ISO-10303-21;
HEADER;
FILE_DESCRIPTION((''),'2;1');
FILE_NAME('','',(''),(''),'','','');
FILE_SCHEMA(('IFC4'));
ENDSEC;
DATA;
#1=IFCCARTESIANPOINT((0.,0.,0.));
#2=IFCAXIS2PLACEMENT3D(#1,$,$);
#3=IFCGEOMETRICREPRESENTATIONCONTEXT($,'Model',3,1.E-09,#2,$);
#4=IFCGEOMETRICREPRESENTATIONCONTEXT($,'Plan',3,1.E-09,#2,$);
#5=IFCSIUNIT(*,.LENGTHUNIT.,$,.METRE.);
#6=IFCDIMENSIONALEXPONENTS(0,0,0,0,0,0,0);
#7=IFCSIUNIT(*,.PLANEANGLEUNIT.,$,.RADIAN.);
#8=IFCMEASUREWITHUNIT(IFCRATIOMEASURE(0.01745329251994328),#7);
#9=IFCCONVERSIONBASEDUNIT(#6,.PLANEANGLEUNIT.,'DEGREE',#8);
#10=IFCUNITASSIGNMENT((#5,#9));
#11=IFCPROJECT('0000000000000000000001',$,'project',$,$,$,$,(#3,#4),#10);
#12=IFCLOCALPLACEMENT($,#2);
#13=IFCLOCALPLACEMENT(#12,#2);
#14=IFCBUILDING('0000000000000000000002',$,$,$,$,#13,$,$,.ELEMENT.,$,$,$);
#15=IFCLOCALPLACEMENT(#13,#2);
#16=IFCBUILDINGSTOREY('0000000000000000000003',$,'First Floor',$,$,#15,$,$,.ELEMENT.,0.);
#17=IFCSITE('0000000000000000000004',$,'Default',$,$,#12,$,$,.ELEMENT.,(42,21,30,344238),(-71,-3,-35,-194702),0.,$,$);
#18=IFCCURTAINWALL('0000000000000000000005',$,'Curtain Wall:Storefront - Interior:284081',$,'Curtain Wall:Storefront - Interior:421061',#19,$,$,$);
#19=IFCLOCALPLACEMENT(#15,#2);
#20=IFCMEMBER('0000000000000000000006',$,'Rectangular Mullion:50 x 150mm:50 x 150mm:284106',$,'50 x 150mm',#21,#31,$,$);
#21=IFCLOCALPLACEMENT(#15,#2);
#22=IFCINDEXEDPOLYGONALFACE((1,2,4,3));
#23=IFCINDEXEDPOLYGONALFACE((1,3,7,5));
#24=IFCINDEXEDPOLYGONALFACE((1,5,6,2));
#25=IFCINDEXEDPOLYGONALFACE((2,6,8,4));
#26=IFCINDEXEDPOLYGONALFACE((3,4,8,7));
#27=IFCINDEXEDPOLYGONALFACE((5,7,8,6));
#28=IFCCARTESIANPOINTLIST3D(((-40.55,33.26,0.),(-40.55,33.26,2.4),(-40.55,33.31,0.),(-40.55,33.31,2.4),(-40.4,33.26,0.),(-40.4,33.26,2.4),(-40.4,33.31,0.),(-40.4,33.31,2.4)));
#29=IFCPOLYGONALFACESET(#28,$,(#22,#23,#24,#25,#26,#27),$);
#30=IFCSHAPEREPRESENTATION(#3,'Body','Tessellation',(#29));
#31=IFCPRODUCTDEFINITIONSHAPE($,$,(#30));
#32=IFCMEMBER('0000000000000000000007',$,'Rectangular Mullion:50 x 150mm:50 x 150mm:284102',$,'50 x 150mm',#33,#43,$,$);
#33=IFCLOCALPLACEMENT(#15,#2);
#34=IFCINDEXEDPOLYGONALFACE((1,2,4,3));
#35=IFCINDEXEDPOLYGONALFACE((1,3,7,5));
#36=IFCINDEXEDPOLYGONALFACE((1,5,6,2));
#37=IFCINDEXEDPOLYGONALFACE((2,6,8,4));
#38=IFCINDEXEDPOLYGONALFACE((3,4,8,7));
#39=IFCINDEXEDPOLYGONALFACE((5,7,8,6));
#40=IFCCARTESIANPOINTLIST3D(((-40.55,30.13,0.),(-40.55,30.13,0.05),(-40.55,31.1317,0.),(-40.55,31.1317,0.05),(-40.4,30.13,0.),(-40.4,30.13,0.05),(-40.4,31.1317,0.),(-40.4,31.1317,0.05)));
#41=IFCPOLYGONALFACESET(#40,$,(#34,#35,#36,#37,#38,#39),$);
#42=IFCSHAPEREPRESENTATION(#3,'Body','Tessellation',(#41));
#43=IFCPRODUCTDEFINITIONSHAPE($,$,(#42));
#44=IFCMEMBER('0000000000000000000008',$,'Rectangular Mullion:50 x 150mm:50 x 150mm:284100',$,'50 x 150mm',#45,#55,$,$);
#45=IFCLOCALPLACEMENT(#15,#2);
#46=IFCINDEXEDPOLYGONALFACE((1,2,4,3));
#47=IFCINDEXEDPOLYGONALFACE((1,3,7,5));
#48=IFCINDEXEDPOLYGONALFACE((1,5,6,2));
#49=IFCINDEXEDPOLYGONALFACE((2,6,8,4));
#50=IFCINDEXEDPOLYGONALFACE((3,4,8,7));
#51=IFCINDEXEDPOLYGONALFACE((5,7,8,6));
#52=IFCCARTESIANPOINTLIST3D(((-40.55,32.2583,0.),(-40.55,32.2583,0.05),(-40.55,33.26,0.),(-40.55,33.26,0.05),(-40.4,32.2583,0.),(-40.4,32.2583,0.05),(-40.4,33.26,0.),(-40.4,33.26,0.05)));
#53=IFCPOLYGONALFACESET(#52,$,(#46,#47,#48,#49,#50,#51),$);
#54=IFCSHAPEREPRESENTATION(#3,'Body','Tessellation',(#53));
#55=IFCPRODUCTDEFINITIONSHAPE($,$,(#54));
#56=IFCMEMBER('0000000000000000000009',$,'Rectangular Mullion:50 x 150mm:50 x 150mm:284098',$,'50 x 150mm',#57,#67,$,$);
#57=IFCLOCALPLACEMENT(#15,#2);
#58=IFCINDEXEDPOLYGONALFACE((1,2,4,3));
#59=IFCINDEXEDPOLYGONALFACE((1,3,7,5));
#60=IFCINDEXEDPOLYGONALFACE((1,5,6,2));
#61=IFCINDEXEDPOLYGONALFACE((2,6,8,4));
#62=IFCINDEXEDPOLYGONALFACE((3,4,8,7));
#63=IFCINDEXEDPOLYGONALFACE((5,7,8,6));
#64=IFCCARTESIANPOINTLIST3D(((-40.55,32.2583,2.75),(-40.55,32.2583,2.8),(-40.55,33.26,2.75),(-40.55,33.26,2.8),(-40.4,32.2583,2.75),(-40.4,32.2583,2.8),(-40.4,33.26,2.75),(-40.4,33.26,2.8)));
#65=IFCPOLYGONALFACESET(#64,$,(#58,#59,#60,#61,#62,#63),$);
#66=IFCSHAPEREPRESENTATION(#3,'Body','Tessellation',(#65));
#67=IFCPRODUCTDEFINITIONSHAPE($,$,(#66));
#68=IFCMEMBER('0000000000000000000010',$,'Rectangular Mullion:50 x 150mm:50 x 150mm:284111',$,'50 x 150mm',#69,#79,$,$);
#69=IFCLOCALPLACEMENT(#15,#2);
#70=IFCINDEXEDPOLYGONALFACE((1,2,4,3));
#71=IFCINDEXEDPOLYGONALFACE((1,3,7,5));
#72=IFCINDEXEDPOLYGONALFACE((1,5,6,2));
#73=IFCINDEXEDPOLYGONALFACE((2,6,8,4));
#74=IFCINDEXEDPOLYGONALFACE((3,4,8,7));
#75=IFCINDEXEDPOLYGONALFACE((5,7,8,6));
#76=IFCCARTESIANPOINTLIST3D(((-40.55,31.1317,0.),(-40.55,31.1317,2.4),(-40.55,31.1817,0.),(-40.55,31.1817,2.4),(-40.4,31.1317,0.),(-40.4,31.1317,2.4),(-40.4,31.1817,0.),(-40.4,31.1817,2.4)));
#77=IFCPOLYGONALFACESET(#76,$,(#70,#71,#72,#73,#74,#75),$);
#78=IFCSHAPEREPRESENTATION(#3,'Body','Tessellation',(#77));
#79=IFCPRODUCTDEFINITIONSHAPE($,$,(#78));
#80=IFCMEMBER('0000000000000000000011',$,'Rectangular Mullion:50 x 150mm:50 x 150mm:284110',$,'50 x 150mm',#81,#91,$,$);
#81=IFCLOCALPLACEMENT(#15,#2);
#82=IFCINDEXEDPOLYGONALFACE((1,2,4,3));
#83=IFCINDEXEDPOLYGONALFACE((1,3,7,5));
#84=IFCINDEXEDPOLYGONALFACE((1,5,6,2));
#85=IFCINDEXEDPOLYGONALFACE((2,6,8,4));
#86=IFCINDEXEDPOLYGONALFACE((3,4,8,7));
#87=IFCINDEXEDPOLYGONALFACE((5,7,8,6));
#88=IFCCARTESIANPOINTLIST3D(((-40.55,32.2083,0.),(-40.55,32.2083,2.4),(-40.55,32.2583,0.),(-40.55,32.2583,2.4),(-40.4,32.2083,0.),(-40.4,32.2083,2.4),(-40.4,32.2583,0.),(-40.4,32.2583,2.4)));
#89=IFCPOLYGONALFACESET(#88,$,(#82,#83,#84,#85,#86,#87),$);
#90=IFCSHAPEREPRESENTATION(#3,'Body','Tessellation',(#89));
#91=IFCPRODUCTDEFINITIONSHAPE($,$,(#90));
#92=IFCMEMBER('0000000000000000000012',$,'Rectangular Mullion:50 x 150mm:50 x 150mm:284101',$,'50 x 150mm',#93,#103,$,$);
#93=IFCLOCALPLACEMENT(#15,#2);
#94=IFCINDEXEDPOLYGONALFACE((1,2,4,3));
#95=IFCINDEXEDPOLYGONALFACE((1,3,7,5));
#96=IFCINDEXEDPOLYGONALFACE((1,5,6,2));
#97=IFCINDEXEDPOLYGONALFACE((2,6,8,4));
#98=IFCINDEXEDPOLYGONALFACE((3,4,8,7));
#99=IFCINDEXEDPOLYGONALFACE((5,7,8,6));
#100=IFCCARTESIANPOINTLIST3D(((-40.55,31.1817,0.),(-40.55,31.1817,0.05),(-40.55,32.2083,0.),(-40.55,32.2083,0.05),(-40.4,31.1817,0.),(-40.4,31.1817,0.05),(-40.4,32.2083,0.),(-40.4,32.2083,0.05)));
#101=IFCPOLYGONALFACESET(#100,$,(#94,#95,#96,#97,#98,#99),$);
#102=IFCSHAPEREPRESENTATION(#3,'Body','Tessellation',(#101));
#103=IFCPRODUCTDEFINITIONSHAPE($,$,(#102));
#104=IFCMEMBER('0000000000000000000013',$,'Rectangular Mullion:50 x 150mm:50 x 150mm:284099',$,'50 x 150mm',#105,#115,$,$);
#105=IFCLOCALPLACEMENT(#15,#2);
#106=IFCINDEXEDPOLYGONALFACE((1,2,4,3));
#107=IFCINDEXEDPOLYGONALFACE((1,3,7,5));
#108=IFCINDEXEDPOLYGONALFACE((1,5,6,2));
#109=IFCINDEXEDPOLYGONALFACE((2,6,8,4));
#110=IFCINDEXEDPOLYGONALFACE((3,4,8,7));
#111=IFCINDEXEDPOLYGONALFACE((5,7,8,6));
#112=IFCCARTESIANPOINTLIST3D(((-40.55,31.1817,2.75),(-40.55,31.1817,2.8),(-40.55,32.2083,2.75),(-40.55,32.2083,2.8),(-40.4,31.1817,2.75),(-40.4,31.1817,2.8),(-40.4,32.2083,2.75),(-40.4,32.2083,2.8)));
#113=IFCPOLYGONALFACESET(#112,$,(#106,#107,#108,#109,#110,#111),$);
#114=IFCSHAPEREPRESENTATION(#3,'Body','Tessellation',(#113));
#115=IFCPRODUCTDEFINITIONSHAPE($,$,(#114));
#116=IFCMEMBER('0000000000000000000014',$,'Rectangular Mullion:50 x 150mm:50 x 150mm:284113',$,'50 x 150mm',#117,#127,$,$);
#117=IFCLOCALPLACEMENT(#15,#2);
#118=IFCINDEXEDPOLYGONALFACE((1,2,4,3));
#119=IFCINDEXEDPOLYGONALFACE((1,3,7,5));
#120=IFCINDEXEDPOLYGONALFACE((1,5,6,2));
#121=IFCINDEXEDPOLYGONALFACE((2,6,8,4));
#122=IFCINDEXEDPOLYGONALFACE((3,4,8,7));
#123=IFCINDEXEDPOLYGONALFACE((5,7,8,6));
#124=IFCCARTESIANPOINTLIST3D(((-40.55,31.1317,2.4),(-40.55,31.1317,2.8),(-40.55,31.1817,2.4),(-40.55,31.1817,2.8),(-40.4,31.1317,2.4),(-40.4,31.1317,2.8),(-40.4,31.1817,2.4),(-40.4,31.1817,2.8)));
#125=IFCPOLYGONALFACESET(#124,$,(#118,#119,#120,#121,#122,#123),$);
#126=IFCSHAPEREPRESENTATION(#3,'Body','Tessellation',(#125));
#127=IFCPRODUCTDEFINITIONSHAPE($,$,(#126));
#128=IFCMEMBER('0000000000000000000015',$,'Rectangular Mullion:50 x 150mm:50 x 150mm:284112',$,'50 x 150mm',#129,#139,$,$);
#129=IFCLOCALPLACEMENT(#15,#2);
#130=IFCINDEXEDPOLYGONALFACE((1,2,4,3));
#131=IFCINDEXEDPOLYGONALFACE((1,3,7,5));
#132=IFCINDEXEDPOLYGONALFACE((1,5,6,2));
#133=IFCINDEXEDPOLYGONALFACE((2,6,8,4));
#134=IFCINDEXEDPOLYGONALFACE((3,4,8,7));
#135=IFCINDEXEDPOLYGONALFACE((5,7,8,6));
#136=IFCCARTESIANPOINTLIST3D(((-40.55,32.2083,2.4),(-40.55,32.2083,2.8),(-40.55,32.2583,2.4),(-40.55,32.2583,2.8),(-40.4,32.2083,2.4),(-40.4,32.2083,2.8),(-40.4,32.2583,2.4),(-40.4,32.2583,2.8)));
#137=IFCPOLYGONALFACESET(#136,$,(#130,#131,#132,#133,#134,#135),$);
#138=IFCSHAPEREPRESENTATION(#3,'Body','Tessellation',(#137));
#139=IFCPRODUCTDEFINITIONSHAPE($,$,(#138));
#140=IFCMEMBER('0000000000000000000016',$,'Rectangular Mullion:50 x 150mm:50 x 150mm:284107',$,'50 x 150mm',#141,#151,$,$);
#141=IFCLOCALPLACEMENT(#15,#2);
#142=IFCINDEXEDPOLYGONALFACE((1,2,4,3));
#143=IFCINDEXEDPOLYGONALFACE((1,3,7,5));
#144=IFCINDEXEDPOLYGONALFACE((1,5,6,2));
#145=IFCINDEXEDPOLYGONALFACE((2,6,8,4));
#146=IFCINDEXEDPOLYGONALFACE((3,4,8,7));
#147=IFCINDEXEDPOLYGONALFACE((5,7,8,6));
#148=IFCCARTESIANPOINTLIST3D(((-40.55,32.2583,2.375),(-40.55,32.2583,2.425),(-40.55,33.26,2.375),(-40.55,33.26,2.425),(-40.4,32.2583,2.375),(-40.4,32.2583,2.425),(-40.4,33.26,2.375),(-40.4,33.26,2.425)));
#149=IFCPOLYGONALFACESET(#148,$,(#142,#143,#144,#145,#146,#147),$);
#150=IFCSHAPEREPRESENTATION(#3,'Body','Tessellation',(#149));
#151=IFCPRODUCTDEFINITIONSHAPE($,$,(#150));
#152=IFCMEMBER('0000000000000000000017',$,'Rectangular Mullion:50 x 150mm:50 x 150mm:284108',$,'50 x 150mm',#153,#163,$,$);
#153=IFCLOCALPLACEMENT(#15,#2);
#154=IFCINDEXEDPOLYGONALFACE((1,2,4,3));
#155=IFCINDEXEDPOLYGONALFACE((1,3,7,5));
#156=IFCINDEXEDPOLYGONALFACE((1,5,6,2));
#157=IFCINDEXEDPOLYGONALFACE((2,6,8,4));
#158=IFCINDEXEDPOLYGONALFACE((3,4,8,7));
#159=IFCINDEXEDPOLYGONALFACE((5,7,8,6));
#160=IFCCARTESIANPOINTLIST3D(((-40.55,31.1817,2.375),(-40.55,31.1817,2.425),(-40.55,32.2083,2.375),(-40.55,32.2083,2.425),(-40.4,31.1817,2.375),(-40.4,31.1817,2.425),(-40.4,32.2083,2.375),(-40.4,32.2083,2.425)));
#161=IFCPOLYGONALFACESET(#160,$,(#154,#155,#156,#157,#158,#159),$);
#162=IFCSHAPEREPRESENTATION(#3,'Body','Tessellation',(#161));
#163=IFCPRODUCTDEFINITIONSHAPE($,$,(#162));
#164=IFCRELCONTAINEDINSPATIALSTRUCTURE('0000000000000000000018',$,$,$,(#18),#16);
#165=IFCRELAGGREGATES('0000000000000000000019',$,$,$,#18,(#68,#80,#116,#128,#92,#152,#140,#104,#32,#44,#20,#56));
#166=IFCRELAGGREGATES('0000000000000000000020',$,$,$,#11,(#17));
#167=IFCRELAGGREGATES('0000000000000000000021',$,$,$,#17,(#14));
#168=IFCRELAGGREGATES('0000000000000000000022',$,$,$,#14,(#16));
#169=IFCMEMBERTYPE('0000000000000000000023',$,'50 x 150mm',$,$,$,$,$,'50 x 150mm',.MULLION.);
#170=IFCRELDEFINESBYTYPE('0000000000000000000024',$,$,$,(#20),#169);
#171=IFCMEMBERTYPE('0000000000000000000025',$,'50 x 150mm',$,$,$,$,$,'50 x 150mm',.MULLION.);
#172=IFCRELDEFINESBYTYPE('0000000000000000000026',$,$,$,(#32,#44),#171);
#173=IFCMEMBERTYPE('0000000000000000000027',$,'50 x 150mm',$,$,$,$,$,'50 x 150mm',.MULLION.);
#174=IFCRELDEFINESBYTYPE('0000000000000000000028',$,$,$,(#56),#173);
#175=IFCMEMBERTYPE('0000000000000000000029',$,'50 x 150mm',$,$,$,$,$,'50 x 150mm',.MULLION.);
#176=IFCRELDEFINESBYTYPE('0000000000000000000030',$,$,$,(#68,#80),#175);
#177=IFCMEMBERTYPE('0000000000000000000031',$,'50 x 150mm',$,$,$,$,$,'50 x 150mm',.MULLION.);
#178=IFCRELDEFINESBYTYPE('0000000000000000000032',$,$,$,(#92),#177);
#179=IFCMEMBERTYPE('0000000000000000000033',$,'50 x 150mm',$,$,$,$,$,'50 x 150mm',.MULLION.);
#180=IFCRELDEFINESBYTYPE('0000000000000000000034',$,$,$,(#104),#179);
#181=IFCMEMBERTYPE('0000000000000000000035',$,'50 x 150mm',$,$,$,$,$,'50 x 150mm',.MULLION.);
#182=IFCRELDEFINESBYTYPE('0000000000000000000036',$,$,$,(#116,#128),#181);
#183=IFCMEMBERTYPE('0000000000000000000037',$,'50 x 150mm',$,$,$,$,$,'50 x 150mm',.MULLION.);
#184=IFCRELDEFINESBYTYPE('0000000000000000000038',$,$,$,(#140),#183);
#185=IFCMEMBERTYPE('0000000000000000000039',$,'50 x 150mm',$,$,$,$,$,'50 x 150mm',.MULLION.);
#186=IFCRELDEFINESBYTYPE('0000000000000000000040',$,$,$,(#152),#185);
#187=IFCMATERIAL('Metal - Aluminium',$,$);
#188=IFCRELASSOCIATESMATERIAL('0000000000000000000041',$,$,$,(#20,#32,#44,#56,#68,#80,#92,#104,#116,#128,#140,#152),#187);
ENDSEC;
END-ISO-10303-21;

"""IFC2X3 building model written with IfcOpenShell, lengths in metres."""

from ifc_helpers import new_model, entity, si_unit, converted_unit, frame, origin, origin_2d_with_axis, place, context, project, spatial, rectangle, extrude, source, transform, mapped, material, type_object, type_shapes, element, aggregate, save


model = new_model("IFC2X3")

# Units and contexts
model_context = context("Model", 3, precision=1e-09, world=origin())
plan_context = context("Plan", 3, precision=1e-09, world=origin())
ifc_project = project(units=[si_unit("LENGTHUNIT", "METRE"), converted_unit("PLANEANGLEUNIT", "DEGREE", entity("IfcRatioMeasure", 0.01745329251994328), si_unit("PLANEANGLEUNIT", "RADIAN"), dimensions=[0, 0, 0, 0, 0, 0, 0])], contexts=[model_context, plan_context])

# Site, building, storey
site_placement = place(None, origin())
site = spatial("IfcSite", under=ifc_project, at=site_placement, Name="Default", CompositionType="ELEMENT", RefLatitude=(42, 21, 30, 344238), RefLongitude=(-71, -3, -35, -194702), RefElevation=0.0)
building_placement = place(site_placement, origin())
building = spatial("IfcBuilding", under=site, at=building_placement, CompositionType="ELEMENT")
storey_placement = place(building_placement, origin())
storey = spatial("IfcBuildingStorey", under=building, at=storey_placement, Name="First Floor", CompositionType="ELEMENT", Elevation=0.0)

# Curtain wall, members
curtain_wall_placement = place(storey_placement, origin())
curtain_wall = element("IfcCurtainWall", 1, at=curtain_wall_placement, inside=storey, Name="Curtain Wall:Storefront - Interior:284081", ObjectType="Curtain Wall:Storefront - Interior:421061")
ifc_material_1 = material(Name="Metal - Aluminium")
member_type_1 = type_object("IfcMemberType", Name="50 x 150mm", ElementType="50 x 150mm", PredefinedType="MULLION")
shared_shape_1 = source(origin(), model_context, "Body", "SweptSolid", [
    extrude(rectangle(XDim=0.05, YDim=0.15, at=origin_2d_with_axis()), frame((-0.025, 0.0, -2.4), z_axis=(0.0, 0.0, 1.0), x_axis=(-1.0, 0.0, 0.0)), (0.0, 0.0, 1.0), 2.4),
])
type_shapes(member_type_1, [shared_shape_1])
member_1_placement = place(storey_placement, frame((-40.475, 33.31, 2.4), z_axis=(0.0, 0.0, 1.0), x_axis=(0.0, 1.0, 0.0)))
member_1 = element("IfcMember", 2, at=member_1_placement, type_object=member_type_1, material=ifc_material_1, Name="Rectangular Mullion:50 x 150mm:50 x 150mm:284106", ObjectType="50 x 150mm", context=model_context, shape_type="MappedRepresentation", body=[
    mapped(shared_shape_1, transform((0.0, 0.0, 0.0), scale=1.0)),
])
member_type_2 = type_object("IfcMemberType", Name="50 x 150mm", ElementType="50 x 150mm", PredefinedType="MULLION")
shared_shape_2 = source(origin(), model_context, "Body", "SweptSolid", [
    extrude(rectangle(XDim=0.05, YDim=0.15, at=origin_2d_with_axis()), frame((-0.025, 0.0, -1.0017), z_axis=(0.0, 0.0, 1.0), x_axis=(-1.0, 0.0, 0.0)), (0.0, 0.0, 1.0), 1.0017),
])
type_shapes(member_type_2, [shared_shape_2])
member_2_placement = place(storey_placement, frame((-40.475, 31.1317, 0.0), z_axis=(0.0, 1.0, 0.0), x_axis=(0.0, 0.0, -1.0)))
member_2 = element("IfcMember", 3, at=member_2_placement, type_object=member_type_2, material=ifc_material_1, Name="Rectangular Mullion:50 x 150mm:50 x 150mm:284102", ObjectType="50 x 150mm", context=model_context, shape_type="MappedRepresentation", body=[
    mapped(shared_shape_2, transform((0.0, 0.0, 0.0), scale=1.0)),
])
member_3_placement = place(storey_placement, frame((-40.475, 33.26, 0.0), z_axis=(0.0, 1.0, 0.0), x_axis=(0.0, 0.0, -1.0)))
member_3 = element("IfcMember", 4, at=member_3_placement, type_object=member_type_2, material=ifc_material_1, Name="Rectangular Mullion:50 x 150mm:50 x 150mm:284100", ObjectType="50 x 150mm", context=model_context, shape_type="MappedRepresentation", body=[
    mapped(shared_shape_2, transform((0.0, 0.0, 0.0), scale=1.0)),
])
member_type_3 = type_object("IfcMemberType", Name="50 x 150mm", ElementType="50 x 150mm", PredefinedType="MULLION")
type_shapes(member_type_3, [shared_shape_2])
member_4_placement = place(storey_placement, frame((-40.475, 32.2583, 2.8), z_axis=(0.0, -1.0, 0.0), x_axis=(0.0, 0.0, 1.0)))
member_4 = element("IfcMember", 5, at=member_4_placement, type_object=member_type_3, material=ifc_material_1, Name="Rectangular Mullion:50 x 150mm:50 x 150mm:284098", ObjectType="50 x 150mm", context=model_context, shape_type="MappedRepresentation", body=[
    mapped(shared_shape_2, transform((0.0, 0.0, 0.0), scale=1.0)),
])
member_type_4 = type_object("IfcMemberType", Name="50 x 150mm", ElementType="50 x 150mm", PredefinedType="MULLION")
shared_shape_3 = source(origin(), model_context, "Body", "SweptSolid", [
    extrude(rectangle(XDim=0.05, YDim=0.15, at=origin_2d_with_axis()), frame((0.0, 0.0, -2.4), z_axis=(0.0, 0.0, 1.0), x_axis=(-1.0, 0.0, 0.0)), (0.0, 0.0, 1.0), 2.4),
])
type_shapes(member_type_4, [shared_shape_3])
member_5_placement = place(storey_placement, frame((-40.475, 31.1567, 0.0), z_axis=(0.0, 0.0, -1.0), x_axis=(0.0, -1.0, 0.0)))
member_5 = element("IfcMember", 6, at=member_5_placement, type_object=member_type_4, material=ifc_material_1, Name="Rectangular Mullion:50 x 150mm:50 x 150mm:284111", ObjectType="50 x 150mm", context=model_context, shape_type="MappedRepresentation", body=[
    mapped(shared_shape_3, transform((0.0, 0.0, 0.0), scale=1.0)),
])
member_6_placement = place(storey_placement, frame((-40.475, 32.2333, 0.0), z_axis=(0.0, 0.0, -1.0), x_axis=(0.0, -1.0, 0.0)))
member_6 = element("IfcMember", 7, at=member_6_placement, type_object=member_type_4, material=ifc_material_1, Name="Rectangular Mullion:50 x 150mm:50 x 150mm:284110", ObjectType="50 x 150mm", context=model_context, shape_type="MappedRepresentation", body=[
    mapped(shared_shape_3, transform((0.0, 0.0, 0.0), scale=1.0)),
])
member_type_5 = type_object("IfcMemberType", Name="50 x 150mm", ElementType="50 x 150mm", PredefinedType="MULLION")
shared_shape_4 = source(origin(), model_context, "Body", "SweptSolid", [
    extrude(rectangle(XDim=0.05, YDim=0.15, at=origin_2d_with_axis()), frame((-0.025, 0.0, -1.0267), z_axis=(0.0, 0.0, 1.0), x_axis=(-1.0, 0.0, 0.0)), (0.0, 0.0, 1.0), 1.0267),
])
type_shapes(member_type_5, [shared_shape_4])
member_7_placement = place(storey_placement, frame((-40.475, 32.2083, 0.0), z_axis=(0.0, 1.0, 0.0), x_axis=(0.0, 0.0, -1.0)))
member_7 = element("IfcMember", 8, at=member_7_placement, type_object=member_type_5, material=ifc_material_1, Name="Rectangular Mullion:50 x 150mm:50 x 150mm:284101", ObjectType="50 x 150mm", context=model_context, shape_type="MappedRepresentation", body=[
    mapped(shared_shape_4, transform((0.0, 0.0, 0.0), scale=1.0)),
])
member_type_6 = type_object("IfcMemberType", Name="50 x 150mm", ElementType="50 x 150mm", PredefinedType="MULLION")
type_shapes(member_type_6, [shared_shape_4])
member_8_placement = place(storey_placement, frame((-40.475, 31.1817, 2.8), z_axis=(0.0, -1.0, 0.0), x_axis=(0.0, 0.0, 1.0)))
member_8 = element("IfcMember", 9, at=member_8_placement, type_object=member_type_6, material=ifc_material_1, Name="Rectangular Mullion:50 x 150mm:50 x 150mm:284099", ObjectType="50 x 150mm", context=model_context, shape_type="MappedRepresentation", body=[
    mapped(shared_shape_4, transform((0.0, 0.0, 0.0), scale=1.0)),
])
member_type_7 = type_object("IfcMemberType", Name="50 x 150mm", ElementType="50 x 150mm", PredefinedType="MULLION")
shared_shape_5 = source(origin(), model_context, "Body", "SweptSolid", [
    extrude(rectangle(XDim=0.05, YDim=0.15, at=origin_2d_with_axis()), frame((0.0, 0.0, -0.4), z_axis=(0.0, 0.0, 1.0), x_axis=(-1.0, 0.0, 0.0)), (0.0, 0.0, 1.0), 0.4),
])
type_shapes(member_type_7, [shared_shape_5])
member_9_placement = place(storey_placement, frame((-40.475, 31.1567, 2.4), z_axis=(0.0, 0.0, -1.0), x_axis=(0.0, -1.0, 0.0)))
member_9 = element("IfcMember", 10, at=member_9_placement, type_object=member_type_7, material=ifc_material_1, Name="Rectangular Mullion:50 x 150mm:50 x 150mm:284113", ObjectType="50 x 150mm", context=model_context, shape_type="MappedRepresentation", body=[
    mapped(shared_shape_5, transform((0.0, 0.0, 0.0), scale=1.0)),
])
member_10_placement = place(storey_placement, frame((-40.475, 32.2333, 2.4), z_axis=(0.0, 0.0, -1.0), x_axis=(0.0, -1.0, 0.0)))
member_10 = element("IfcMember", 11, at=member_10_placement, type_object=member_type_7, material=ifc_material_1, Name="Rectangular Mullion:50 x 150mm:50 x 150mm:284112", ObjectType="50 x 150mm", context=model_context, shape_type="MappedRepresentation", body=[
    mapped(shared_shape_5, transform((0.0, 0.0, 0.0), scale=1.0)),
])
member_type_8 = type_object("IfcMemberType", Name="50 x 150mm", ElementType="50 x 150mm", PredefinedType="MULLION")
shared_shape_6 = source(origin(), model_context, "Body", "SweptSolid", [
    extrude(rectangle(XDim=0.05, YDim=0.15, at=origin_2d_with_axis()), frame((0.0, 0.0, -1.0017), z_axis=(0.0, 0.0, 1.0), x_axis=(-1.0, 0.0, 0.0)), (0.0, 0.0, 1.0), 1.0017),
])
type_shapes(member_type_8, [shared_shape_6])
member_11_placement = place(storey_placement, frame((-40.475, 32.2583, 2.4), z_axis=(0.0, -1.0, 0.0), x_axis=(0.0, 0.0, 1.0)))
member_11 = element("IfcMember", 12, at=member_11_placement, type_object=member_type_8, material=ifc_material_1, Name="Rectangular Mullion:50 x 150mm:50 x 150mm:284107", ObjectType="50 x 150mm", context=model_context, shape_type="MappedRepresentation", body=[
    mapped(shared_shape_6, transform((0.0, 0.0, 0.0), scale=1.0)),
])
member_type_9 = type_object("IfcMemberType", Name="50 x 150mm", ElementType="50 x 150mm", PredefinedType="MULLION")
shared_shape_7 = source(origin(), model_context, "Body", "SweptSolid", [
    extrude(rectangle(XDim=0.05, YDim=0.15, at=origin_2d_with_axis()), frame((0.0, 0.0, -1.0267), z_axis=(0.0, 0.0, 1.0), x_axis=(-1.0, 0.0, 0.0)), (0.0, 0.0, 1.0), 1.0267),
])
type_shapes(member_type_9, [shared_shape_7])
member_12_placement = place(storey_placement, frame((-40.475, 31.1817, 2.4), z_axis=(0.0, -1.0, 0.0), x_axis=(0.0, 0.0, 1.0)))
member_12 = element("IfcMember", 13, at=member_12_placement, type_object=member_type_9, material=ifc_material_1, Name="Rectangular Mullion:50 x 150mm:50 x 150mm:284108", ObjectType="50 x 150mm", context=model_context, shape_type="MappedRepresentation", body=[
    mapped(shared_shape_7, transform((0.0, 0.0, 0.0), scale=1.0)),
])
aggregate(curtain_wall, [member_5, member_6, member_9, member_10, member_7, member_12, member_11, member_8, member_2, member_3, member_1, member_4])

save(model, "model.ifc")
